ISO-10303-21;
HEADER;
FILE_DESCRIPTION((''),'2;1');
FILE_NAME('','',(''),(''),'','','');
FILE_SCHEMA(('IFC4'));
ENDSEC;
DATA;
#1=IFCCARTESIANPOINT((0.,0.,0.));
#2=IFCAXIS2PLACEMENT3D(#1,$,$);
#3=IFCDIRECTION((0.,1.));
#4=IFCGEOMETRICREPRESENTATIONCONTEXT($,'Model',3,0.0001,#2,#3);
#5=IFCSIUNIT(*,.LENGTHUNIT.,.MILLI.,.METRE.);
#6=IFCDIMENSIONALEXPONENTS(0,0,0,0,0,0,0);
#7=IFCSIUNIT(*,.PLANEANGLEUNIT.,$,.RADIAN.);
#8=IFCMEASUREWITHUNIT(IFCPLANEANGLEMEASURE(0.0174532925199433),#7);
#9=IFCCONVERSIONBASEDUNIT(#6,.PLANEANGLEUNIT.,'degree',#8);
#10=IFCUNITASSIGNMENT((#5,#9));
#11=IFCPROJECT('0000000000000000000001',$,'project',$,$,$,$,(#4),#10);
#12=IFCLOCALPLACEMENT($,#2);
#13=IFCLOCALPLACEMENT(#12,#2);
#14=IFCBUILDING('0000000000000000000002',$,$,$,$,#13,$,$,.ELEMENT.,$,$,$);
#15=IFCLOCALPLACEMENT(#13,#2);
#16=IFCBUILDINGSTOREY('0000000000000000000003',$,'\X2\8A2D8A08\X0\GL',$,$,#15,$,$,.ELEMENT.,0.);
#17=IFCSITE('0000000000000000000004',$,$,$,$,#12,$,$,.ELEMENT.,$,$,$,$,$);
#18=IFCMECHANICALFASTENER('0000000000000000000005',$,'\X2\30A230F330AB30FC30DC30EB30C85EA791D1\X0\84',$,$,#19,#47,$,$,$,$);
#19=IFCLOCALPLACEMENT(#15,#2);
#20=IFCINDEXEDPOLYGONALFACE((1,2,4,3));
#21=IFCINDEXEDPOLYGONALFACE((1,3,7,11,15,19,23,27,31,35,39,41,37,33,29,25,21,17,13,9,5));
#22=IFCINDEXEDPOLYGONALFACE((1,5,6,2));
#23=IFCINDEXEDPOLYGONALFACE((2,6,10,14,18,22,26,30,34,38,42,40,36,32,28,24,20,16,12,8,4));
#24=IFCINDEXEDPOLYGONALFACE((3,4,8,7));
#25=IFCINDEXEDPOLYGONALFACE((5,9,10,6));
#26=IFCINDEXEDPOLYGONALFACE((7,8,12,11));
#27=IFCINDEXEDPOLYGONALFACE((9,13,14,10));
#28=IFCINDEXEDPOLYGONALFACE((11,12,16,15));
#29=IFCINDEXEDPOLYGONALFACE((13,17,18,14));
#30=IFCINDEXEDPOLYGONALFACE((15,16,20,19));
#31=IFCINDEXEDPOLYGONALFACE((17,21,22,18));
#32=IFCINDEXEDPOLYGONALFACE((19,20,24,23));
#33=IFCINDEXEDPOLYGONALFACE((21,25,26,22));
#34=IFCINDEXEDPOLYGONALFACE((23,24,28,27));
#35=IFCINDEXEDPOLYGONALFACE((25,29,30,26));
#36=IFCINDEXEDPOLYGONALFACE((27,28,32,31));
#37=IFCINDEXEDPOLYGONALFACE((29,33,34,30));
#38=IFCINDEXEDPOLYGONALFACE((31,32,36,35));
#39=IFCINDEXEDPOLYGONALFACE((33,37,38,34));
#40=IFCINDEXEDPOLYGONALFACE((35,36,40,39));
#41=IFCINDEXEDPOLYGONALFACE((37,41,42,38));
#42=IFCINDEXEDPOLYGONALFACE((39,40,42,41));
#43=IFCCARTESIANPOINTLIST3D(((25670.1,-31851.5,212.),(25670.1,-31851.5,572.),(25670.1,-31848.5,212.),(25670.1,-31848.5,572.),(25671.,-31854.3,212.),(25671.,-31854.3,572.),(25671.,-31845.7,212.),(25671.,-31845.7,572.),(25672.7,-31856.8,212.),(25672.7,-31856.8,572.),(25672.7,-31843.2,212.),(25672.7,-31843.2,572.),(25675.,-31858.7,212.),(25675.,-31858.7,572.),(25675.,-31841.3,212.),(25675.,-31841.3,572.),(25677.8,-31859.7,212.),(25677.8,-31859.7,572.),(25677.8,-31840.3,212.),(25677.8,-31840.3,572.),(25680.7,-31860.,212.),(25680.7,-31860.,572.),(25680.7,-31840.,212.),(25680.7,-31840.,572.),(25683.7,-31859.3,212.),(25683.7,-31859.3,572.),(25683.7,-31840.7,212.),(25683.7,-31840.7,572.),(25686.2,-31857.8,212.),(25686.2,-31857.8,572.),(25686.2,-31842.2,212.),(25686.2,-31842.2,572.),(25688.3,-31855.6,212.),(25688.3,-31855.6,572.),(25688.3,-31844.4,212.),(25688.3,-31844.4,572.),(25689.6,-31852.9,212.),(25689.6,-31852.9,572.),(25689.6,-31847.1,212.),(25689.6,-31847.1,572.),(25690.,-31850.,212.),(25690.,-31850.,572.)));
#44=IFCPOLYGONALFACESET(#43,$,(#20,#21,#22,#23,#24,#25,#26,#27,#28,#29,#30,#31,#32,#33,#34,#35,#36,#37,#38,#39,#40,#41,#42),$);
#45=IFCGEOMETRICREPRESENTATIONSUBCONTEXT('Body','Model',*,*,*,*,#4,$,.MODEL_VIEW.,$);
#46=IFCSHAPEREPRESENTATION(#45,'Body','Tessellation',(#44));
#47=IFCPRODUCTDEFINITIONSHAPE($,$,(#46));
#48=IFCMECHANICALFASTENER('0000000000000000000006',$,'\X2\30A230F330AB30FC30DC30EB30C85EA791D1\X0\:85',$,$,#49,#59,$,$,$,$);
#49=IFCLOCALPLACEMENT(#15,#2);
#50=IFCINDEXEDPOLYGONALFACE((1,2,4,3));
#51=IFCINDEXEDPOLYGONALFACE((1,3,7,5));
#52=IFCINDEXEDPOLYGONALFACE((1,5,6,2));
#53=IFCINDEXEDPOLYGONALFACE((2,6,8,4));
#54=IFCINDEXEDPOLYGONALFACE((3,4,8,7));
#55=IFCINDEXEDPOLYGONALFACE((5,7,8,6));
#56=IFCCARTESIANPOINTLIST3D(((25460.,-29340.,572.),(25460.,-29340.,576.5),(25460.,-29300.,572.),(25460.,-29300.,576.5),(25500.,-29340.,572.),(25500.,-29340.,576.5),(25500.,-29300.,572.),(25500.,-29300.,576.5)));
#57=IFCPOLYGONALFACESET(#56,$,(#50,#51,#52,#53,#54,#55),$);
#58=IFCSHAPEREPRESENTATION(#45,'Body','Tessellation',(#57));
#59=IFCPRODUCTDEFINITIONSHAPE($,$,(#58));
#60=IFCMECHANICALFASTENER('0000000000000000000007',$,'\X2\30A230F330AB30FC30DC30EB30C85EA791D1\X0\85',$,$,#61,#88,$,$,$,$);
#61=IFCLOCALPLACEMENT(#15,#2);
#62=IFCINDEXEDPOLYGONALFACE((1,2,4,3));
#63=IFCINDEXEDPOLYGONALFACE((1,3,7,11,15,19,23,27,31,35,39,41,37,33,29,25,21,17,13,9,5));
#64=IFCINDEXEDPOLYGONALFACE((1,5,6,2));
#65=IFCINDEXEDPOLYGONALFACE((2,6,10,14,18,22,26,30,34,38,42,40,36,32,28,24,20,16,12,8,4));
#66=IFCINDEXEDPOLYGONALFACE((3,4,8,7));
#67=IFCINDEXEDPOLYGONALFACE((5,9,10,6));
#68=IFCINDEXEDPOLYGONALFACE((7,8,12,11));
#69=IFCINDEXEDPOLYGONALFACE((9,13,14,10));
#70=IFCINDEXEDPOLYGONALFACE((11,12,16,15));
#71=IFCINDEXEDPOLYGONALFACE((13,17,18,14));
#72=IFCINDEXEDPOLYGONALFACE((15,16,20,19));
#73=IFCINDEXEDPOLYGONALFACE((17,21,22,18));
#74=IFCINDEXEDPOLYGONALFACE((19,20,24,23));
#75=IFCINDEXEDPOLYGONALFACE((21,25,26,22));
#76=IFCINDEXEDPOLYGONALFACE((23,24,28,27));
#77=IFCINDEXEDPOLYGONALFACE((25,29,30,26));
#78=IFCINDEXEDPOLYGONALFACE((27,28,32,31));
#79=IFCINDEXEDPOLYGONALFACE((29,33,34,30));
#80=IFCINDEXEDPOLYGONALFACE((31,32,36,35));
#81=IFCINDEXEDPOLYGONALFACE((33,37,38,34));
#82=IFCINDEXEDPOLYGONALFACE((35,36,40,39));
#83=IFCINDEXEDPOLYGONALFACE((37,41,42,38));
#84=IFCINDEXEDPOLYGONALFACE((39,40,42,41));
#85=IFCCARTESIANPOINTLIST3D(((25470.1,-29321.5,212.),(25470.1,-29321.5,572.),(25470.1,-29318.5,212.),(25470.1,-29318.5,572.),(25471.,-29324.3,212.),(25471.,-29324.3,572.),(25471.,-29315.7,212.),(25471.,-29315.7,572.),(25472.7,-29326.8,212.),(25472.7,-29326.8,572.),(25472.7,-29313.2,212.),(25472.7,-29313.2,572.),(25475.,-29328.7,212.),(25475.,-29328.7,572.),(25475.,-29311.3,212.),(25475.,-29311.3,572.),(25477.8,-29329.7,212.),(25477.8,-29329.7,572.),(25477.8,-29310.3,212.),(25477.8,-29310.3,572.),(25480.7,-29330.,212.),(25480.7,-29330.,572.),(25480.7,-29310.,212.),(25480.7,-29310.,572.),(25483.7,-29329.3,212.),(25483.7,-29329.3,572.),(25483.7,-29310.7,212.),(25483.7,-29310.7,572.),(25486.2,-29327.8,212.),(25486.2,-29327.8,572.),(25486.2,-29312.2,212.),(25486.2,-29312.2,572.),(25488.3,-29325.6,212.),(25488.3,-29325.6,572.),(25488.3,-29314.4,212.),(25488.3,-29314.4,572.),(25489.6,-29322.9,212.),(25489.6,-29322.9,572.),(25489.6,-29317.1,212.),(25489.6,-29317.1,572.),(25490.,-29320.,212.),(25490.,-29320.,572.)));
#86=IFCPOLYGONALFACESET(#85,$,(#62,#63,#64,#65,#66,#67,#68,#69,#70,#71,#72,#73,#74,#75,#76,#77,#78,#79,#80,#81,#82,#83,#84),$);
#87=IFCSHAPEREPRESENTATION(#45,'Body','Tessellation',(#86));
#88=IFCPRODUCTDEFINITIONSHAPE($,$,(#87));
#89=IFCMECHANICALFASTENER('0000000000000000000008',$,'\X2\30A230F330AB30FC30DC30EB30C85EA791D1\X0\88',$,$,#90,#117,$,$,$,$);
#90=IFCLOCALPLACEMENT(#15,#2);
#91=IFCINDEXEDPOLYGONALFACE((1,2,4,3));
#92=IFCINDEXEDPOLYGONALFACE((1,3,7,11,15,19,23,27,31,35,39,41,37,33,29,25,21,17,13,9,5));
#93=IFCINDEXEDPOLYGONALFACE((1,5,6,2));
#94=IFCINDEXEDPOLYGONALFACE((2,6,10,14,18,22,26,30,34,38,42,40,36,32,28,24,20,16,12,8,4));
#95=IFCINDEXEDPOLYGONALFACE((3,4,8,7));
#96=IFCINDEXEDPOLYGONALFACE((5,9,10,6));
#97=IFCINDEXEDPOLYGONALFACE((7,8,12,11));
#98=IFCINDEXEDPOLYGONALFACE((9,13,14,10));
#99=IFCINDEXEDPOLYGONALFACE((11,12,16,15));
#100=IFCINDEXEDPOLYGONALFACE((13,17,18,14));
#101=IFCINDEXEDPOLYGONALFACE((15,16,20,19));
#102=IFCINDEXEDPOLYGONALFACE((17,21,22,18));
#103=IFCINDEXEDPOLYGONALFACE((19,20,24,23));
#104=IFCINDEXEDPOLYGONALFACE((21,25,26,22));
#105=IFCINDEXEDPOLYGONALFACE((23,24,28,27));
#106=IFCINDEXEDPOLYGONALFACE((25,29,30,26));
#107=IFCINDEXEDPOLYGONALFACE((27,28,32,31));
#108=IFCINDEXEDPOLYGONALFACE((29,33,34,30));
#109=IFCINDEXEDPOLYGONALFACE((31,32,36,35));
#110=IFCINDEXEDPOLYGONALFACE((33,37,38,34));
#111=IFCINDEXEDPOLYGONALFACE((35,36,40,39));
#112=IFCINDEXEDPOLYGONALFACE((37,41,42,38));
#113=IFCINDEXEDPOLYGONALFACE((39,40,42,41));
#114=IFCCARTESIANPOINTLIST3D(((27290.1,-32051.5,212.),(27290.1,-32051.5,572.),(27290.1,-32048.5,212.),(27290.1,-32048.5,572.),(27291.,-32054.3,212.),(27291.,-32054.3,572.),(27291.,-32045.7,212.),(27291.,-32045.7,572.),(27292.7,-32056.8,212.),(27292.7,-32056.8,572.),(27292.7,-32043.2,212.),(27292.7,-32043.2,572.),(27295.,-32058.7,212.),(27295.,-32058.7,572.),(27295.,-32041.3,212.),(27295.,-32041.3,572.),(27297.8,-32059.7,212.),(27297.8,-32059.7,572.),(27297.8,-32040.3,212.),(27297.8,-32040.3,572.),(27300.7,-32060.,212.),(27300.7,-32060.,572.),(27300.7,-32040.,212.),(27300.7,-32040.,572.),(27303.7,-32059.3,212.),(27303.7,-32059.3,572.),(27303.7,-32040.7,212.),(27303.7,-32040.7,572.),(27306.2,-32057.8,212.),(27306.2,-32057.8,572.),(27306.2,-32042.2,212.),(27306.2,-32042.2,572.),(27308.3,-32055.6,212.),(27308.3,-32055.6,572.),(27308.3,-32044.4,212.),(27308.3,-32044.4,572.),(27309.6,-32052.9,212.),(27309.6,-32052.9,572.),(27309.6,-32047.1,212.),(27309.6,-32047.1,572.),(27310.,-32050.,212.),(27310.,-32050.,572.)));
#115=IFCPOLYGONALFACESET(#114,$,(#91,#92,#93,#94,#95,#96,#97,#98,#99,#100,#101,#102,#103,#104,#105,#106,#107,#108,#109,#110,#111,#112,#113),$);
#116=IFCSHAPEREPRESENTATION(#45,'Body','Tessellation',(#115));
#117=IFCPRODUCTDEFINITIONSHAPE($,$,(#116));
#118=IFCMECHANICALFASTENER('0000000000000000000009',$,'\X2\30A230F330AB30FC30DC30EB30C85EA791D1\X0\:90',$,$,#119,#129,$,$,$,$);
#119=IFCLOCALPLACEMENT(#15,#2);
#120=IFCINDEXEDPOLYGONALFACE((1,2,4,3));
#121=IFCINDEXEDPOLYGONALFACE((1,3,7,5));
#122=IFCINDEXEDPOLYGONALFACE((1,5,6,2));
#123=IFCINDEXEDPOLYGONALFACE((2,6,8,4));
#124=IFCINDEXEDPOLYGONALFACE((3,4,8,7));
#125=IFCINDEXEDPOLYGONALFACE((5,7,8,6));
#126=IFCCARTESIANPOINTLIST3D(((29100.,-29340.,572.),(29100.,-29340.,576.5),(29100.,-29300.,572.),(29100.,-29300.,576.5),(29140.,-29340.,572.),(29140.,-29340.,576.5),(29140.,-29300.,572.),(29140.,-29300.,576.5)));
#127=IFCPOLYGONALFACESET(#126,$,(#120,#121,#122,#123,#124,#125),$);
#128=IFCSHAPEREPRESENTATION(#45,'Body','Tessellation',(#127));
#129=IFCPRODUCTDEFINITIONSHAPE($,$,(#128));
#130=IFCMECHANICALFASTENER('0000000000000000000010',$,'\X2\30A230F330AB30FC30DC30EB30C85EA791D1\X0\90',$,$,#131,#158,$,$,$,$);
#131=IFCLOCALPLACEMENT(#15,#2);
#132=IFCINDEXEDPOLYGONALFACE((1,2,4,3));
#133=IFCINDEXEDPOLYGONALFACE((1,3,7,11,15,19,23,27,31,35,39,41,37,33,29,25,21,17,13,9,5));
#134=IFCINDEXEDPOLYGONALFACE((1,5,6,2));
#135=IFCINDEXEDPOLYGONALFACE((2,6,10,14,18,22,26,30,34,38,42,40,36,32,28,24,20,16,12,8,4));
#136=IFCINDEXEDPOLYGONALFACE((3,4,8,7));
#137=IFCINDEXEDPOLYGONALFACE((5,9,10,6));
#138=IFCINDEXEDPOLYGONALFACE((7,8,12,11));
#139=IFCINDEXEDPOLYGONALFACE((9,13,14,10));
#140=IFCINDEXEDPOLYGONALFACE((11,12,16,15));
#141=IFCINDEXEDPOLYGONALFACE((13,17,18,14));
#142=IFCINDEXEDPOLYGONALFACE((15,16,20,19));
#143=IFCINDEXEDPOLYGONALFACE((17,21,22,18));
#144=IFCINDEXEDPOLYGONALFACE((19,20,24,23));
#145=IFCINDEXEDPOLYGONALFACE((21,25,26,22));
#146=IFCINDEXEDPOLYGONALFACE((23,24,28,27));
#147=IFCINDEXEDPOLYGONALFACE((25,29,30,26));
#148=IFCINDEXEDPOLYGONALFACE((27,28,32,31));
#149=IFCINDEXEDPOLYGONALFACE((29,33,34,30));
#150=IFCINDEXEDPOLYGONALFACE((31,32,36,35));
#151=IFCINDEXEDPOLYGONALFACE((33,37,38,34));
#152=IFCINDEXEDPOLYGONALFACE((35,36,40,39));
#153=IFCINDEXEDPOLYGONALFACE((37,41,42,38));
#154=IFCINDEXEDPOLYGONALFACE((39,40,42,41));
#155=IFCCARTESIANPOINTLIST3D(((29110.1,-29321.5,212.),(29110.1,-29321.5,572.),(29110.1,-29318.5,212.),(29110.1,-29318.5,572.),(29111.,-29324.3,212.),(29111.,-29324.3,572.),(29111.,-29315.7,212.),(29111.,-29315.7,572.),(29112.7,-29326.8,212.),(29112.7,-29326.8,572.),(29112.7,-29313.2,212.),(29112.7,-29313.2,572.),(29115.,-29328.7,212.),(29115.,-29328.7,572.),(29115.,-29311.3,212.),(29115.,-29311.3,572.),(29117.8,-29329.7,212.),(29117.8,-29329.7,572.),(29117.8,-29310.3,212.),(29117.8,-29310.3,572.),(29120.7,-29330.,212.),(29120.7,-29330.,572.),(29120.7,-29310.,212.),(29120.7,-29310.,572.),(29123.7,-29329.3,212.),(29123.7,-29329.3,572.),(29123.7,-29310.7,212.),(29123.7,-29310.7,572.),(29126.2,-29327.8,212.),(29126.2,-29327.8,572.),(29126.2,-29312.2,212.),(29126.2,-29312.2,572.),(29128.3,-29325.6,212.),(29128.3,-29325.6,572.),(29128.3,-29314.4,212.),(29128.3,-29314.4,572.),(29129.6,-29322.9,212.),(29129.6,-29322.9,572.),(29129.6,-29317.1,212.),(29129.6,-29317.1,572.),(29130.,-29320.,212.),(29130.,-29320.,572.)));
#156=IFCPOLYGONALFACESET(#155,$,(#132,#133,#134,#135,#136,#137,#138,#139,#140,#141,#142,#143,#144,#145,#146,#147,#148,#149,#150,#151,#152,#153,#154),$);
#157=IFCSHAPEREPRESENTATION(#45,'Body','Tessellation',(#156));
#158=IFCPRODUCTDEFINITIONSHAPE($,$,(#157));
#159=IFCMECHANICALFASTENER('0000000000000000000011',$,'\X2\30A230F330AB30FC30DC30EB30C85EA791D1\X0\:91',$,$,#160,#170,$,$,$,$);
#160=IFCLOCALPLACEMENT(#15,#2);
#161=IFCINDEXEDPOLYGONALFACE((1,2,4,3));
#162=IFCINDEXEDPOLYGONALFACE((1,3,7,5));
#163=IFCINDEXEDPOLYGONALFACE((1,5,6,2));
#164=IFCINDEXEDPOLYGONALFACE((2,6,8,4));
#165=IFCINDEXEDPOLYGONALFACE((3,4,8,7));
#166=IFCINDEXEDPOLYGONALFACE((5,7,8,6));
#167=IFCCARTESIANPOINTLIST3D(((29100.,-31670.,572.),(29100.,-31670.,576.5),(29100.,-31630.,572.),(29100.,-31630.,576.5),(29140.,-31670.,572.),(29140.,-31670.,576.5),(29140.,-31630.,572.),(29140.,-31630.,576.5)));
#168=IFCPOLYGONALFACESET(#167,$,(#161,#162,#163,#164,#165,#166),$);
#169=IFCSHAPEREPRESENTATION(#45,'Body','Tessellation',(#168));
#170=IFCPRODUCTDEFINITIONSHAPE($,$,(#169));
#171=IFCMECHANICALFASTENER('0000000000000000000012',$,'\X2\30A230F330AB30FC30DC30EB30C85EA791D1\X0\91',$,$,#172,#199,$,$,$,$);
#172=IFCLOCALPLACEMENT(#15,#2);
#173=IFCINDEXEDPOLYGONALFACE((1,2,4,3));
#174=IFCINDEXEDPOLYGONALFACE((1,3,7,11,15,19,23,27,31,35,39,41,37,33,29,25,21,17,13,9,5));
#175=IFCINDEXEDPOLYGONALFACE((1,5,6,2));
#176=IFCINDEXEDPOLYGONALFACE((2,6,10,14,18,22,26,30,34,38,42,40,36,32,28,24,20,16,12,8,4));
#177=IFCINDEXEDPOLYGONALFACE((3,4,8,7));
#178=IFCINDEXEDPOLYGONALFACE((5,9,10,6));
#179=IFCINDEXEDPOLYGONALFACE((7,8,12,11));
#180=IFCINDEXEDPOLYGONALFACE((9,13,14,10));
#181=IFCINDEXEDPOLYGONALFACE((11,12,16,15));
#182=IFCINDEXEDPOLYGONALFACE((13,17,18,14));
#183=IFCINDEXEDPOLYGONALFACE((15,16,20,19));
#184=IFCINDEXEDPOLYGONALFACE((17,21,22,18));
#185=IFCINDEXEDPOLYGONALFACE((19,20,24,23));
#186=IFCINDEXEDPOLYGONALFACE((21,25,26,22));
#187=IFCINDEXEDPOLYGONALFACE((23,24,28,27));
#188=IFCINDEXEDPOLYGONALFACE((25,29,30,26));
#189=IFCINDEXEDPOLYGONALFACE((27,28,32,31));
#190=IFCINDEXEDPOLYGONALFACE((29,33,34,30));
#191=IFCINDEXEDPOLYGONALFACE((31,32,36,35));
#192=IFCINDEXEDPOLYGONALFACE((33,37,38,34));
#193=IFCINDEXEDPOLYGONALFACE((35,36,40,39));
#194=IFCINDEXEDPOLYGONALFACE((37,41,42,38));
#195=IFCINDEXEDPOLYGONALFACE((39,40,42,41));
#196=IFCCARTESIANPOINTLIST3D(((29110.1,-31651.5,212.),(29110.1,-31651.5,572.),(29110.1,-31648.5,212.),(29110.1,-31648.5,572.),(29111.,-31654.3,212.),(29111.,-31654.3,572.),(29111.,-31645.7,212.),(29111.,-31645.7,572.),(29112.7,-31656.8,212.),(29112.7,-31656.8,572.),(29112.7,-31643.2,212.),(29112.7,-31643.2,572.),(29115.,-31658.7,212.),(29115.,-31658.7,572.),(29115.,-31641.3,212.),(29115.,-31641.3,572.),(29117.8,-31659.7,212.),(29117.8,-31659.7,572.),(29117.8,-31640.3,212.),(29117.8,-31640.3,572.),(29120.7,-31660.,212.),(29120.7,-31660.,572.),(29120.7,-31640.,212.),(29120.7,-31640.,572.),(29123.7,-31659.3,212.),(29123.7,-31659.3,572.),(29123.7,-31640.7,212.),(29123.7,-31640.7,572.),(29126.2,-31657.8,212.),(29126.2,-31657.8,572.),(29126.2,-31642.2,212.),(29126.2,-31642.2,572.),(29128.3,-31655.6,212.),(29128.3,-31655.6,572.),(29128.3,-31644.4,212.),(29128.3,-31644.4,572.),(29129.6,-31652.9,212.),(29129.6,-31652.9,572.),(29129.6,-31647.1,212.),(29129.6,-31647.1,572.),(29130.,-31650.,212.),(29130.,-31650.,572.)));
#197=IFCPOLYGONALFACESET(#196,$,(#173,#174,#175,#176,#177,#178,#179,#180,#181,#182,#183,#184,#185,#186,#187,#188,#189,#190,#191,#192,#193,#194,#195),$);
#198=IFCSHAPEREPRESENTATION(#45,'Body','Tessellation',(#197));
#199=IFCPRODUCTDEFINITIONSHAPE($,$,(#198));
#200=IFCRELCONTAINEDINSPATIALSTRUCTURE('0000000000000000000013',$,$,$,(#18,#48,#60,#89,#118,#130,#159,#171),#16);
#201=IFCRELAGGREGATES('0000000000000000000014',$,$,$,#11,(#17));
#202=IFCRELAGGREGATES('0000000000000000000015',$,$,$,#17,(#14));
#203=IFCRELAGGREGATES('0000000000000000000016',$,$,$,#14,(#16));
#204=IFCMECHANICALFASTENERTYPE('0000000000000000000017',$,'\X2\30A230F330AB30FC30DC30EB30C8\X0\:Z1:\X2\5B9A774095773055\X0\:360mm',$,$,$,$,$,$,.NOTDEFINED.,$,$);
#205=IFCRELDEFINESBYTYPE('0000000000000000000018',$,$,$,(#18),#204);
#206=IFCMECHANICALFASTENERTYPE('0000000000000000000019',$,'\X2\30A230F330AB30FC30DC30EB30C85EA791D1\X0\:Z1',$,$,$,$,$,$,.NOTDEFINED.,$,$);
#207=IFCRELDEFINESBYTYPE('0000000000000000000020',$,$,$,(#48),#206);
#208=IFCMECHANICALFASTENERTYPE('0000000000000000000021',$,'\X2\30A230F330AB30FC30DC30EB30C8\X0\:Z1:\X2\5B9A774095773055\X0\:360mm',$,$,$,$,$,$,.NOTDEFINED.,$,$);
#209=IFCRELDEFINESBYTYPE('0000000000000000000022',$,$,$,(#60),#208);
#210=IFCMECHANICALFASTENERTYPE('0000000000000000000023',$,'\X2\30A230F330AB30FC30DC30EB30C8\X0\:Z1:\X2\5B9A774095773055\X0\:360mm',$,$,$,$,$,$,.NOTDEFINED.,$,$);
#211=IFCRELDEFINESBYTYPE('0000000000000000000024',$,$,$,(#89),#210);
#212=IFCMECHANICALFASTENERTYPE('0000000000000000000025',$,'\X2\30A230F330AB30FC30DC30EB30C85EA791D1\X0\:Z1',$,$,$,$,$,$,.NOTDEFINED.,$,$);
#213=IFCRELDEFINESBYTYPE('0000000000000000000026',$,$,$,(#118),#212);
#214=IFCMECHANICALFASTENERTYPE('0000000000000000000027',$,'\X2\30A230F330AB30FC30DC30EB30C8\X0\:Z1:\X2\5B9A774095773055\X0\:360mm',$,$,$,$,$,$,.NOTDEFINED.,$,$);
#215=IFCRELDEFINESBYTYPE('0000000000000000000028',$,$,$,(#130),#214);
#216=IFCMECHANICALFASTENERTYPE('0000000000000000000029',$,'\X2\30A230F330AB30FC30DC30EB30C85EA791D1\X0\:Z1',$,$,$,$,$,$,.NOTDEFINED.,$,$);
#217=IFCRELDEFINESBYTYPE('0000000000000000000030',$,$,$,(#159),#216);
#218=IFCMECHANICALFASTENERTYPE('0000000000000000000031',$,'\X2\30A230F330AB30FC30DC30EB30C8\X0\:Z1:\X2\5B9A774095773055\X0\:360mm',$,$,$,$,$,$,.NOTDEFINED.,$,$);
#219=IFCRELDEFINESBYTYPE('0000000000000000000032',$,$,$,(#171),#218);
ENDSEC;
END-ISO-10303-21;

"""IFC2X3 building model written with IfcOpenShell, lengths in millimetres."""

from ifc_helpers import new_model, entity, si_unit, converted_unit, direction, frame, origin, origin_with_axes, origin_2d, place, context, subcontext, project, spatial, rectangle, circle, extrude, type_object, element, save


model = new_model("IFC2X3")

# Units and contexts
model_context = context("Model", 3, precision=0.0001, world=origin(), true_north=direction((0.0, 1.0)))
body_context = subcontext(model_context, "Body", "Model", "MODEL_VIEW")
ifc_project = project(units=[si_unit("LENGTHUNIT", "METRE", prefix="MILLI"), converted_unit("PLANEANGLEUNIT", "degree", entity("IfcPlaneAngleMeasure", 0.0174532925199433), si_unit("PLANEANGLEUNIT", "RADIAN"), dimensions=[0, 0, 0, 0, 0, 0, 0])], contexts=[model_context])

# Site, building, storey
site_placement = place(None, origin())
site = spatial("IfcSite", under=ifc_project, at=site_placement, CompositionType="ELEMENT")
building_placement = place(site_placement, origin())
building = spatial("IfcBuilding", under=site, at=building_placement, CompositionType="ELEMENT")
storey_placement = place(building_placement, origin())
storey = spatial("IfcBuildingStorey", under=building, at=storey_placement, Name="設計GL", CompositionType="ELEMENT", Elevation=0.0)

# Mechanical fasteners
mechanical_fastener_type_1 = type_object("IfcMechanicalFastenerType", Name="アンカーボルト:Z1:定着長さ:360mm")
mechanical_fastener_1_placement = place(storey_placement, frame((25680.0, -31850.0, 212.0)))
element("IfcMechanicalFastener", 1, at=mechanical_fastener_1_placement, inside=storey, type_object=mechanical_fastener_type_1, Name="アンカーボルト座金84", context=body_context, shape_type="SweptSolid", body=[
    extrude(circle(Radius=10.0, at=origin_2d()), origin_with_axes(), (0.0, 0.0, 1.0), 360.0),
])
mechanical_fastener_type_2 = type_object("IfcMechanicalFastenerType", Name="アンカーボルト座金:Z1")
mechanical_fastener_2_placement = place(storey_placement, frame((25480.0, -29320.0, 572.0)))
element("IfcMechanicalFastener", 2, at=mechanical_fastener_2_placement, inside=storey, type_object=mechanical_fastener_type_2, Name="アンカーボルト座金:85", context=body_context, shape_type="SweptSolid", body=[
    extrude(rectangle(XDim=40.0, YDim=40.0, at=origin_2d()), origin_with_axes(), (0.0, 0.0, 1.0), 4.5),
])
mechanical_fastener_type_3 = type_object("IfcMechanicalFastenerType", Name="アンカーボルト:Z1:定着長さ:360mm")
mechanical_fastener_3_placement = place(storey_placement, frame((25480.0, -29320.0, 212.0)))
element("IfcMechanicalFastener", 3, at=mechanical_fastener_3_placement, inside=storey, type_object=mechanical_fastener_type_3, Name="アンカーボルト座金85", context=body_context, shape_type="SweptSolid", body=[
    extrude(circle(Radius=10.0, at=origin_2d()), origin_with_axes(), (0.0, 0.0, 1.0), 360.0),
])
mechanical_fastener_type_4 = type_object("IfcMechanicalFastenerType", Name="アンカーボルト:Z1:定着長さ:360mm")
mechanical_fastener_4_placement = place(storey_placement, frame((27300.0, -32050.0, 212.0)))
element("IfcMechanicalFastener", 4, at=mechanical_fastener_4_placement, inside=storey, type_object=mechanical_fastener_type_4, Name="アンカーボルト座金88", context=body_context, shape_type="SweptSolid", body=[
    extrude(circle(Radius=10.0, at=origin_2d()), origin_with_axes(), (0.0, 0.0, 1.0), 360.0),
])
mechanical_fastener_type_5 = type_object("IfcMechanicalFastenerType", Name="アンカーボルト座金:Z1")
mechanical_fastener_5_placement = place(storey_placement, frame((29120.0, -29320.0, 572.0)))
element("IfcMechanicalFastener", 5, at=mechanical_fastener_5_placement, inside=storey, type_object=mechanical_fastener_type_5, Name="アンカーボルト座金:90", context=body_context, shape_type="SweptSolid", body=[
    extrude(rectangle(XDim=40.0, YDim=40.0, at=origin_2d()), origin_with_axes(), (0.0, 0.0, 1.0), 4.5),
])
mechanical_fastener_type_6 = type_object("IfcMechanicalFastenerType", Name="アンカーボルト:Z1:定着長さ:360mm")
mechanical_fastener_6_placement = place(storey_placement, frame((29120.0, -29320.0, 212.0)))
element("IfcMechanicalFastener", 6, at=mechanical_fastener_6_placement, inside=storey, type_object=mechanical_fastener_type_6, Name="アンカーボルト座金90", context=body_context, shape_type="SweptSolid", body=[
    extrude(circle(Radius=10.0, at=origin_2d()), origin_with_axes(), (0.0, 0.0, 1.0), 360.0),
])
mechanical_fastener_type_7 = type_object("IfcMechanicalFastenerType", Name="アンカーボルト座金:Z1")
mechanical_fastener_7_placement = place(storey_placement, frame((29120.0, -31650.0, 572.0)))
element("IfcMechanicalFastener", 7, at=mechanical_fastener_7_placement, inside=storey, type_object=mechanical_fastener_type_7, Name="アンカーボルト座金:91", context=body_context, shape_type="SweptSolid", body=[
    extrude(rectangle(XDim=40.0, YDim=40.0, at=origin_2d()), origin_with_axes(), (0.0, 0.0, 1.0), 4.5),
])
mechanical_fastener_type_8 = type_object("IfcMechanicalFastenerType", Name="アンカーボルト:Z1:定着長さ:360mm")
mechanical_fastener_8_placement = place(storey_placement, frame((29120.0, -31650.0, 212.0)))
element("IfcMechanicalFastener", 8, at=mechanical_fastener_8_placement, inside=storey, type_object=mechanical_fastener_type_8, Name="アンカーボルト座金91", context=body_context, shape_type="SweptSolid", body=[
    extrude(circle(Radius=10.0, at=origin_2d()), origin_with_axes(), (0.0, 0.0, 1.0), 360.0),
])

save(model, "model.ifc")
